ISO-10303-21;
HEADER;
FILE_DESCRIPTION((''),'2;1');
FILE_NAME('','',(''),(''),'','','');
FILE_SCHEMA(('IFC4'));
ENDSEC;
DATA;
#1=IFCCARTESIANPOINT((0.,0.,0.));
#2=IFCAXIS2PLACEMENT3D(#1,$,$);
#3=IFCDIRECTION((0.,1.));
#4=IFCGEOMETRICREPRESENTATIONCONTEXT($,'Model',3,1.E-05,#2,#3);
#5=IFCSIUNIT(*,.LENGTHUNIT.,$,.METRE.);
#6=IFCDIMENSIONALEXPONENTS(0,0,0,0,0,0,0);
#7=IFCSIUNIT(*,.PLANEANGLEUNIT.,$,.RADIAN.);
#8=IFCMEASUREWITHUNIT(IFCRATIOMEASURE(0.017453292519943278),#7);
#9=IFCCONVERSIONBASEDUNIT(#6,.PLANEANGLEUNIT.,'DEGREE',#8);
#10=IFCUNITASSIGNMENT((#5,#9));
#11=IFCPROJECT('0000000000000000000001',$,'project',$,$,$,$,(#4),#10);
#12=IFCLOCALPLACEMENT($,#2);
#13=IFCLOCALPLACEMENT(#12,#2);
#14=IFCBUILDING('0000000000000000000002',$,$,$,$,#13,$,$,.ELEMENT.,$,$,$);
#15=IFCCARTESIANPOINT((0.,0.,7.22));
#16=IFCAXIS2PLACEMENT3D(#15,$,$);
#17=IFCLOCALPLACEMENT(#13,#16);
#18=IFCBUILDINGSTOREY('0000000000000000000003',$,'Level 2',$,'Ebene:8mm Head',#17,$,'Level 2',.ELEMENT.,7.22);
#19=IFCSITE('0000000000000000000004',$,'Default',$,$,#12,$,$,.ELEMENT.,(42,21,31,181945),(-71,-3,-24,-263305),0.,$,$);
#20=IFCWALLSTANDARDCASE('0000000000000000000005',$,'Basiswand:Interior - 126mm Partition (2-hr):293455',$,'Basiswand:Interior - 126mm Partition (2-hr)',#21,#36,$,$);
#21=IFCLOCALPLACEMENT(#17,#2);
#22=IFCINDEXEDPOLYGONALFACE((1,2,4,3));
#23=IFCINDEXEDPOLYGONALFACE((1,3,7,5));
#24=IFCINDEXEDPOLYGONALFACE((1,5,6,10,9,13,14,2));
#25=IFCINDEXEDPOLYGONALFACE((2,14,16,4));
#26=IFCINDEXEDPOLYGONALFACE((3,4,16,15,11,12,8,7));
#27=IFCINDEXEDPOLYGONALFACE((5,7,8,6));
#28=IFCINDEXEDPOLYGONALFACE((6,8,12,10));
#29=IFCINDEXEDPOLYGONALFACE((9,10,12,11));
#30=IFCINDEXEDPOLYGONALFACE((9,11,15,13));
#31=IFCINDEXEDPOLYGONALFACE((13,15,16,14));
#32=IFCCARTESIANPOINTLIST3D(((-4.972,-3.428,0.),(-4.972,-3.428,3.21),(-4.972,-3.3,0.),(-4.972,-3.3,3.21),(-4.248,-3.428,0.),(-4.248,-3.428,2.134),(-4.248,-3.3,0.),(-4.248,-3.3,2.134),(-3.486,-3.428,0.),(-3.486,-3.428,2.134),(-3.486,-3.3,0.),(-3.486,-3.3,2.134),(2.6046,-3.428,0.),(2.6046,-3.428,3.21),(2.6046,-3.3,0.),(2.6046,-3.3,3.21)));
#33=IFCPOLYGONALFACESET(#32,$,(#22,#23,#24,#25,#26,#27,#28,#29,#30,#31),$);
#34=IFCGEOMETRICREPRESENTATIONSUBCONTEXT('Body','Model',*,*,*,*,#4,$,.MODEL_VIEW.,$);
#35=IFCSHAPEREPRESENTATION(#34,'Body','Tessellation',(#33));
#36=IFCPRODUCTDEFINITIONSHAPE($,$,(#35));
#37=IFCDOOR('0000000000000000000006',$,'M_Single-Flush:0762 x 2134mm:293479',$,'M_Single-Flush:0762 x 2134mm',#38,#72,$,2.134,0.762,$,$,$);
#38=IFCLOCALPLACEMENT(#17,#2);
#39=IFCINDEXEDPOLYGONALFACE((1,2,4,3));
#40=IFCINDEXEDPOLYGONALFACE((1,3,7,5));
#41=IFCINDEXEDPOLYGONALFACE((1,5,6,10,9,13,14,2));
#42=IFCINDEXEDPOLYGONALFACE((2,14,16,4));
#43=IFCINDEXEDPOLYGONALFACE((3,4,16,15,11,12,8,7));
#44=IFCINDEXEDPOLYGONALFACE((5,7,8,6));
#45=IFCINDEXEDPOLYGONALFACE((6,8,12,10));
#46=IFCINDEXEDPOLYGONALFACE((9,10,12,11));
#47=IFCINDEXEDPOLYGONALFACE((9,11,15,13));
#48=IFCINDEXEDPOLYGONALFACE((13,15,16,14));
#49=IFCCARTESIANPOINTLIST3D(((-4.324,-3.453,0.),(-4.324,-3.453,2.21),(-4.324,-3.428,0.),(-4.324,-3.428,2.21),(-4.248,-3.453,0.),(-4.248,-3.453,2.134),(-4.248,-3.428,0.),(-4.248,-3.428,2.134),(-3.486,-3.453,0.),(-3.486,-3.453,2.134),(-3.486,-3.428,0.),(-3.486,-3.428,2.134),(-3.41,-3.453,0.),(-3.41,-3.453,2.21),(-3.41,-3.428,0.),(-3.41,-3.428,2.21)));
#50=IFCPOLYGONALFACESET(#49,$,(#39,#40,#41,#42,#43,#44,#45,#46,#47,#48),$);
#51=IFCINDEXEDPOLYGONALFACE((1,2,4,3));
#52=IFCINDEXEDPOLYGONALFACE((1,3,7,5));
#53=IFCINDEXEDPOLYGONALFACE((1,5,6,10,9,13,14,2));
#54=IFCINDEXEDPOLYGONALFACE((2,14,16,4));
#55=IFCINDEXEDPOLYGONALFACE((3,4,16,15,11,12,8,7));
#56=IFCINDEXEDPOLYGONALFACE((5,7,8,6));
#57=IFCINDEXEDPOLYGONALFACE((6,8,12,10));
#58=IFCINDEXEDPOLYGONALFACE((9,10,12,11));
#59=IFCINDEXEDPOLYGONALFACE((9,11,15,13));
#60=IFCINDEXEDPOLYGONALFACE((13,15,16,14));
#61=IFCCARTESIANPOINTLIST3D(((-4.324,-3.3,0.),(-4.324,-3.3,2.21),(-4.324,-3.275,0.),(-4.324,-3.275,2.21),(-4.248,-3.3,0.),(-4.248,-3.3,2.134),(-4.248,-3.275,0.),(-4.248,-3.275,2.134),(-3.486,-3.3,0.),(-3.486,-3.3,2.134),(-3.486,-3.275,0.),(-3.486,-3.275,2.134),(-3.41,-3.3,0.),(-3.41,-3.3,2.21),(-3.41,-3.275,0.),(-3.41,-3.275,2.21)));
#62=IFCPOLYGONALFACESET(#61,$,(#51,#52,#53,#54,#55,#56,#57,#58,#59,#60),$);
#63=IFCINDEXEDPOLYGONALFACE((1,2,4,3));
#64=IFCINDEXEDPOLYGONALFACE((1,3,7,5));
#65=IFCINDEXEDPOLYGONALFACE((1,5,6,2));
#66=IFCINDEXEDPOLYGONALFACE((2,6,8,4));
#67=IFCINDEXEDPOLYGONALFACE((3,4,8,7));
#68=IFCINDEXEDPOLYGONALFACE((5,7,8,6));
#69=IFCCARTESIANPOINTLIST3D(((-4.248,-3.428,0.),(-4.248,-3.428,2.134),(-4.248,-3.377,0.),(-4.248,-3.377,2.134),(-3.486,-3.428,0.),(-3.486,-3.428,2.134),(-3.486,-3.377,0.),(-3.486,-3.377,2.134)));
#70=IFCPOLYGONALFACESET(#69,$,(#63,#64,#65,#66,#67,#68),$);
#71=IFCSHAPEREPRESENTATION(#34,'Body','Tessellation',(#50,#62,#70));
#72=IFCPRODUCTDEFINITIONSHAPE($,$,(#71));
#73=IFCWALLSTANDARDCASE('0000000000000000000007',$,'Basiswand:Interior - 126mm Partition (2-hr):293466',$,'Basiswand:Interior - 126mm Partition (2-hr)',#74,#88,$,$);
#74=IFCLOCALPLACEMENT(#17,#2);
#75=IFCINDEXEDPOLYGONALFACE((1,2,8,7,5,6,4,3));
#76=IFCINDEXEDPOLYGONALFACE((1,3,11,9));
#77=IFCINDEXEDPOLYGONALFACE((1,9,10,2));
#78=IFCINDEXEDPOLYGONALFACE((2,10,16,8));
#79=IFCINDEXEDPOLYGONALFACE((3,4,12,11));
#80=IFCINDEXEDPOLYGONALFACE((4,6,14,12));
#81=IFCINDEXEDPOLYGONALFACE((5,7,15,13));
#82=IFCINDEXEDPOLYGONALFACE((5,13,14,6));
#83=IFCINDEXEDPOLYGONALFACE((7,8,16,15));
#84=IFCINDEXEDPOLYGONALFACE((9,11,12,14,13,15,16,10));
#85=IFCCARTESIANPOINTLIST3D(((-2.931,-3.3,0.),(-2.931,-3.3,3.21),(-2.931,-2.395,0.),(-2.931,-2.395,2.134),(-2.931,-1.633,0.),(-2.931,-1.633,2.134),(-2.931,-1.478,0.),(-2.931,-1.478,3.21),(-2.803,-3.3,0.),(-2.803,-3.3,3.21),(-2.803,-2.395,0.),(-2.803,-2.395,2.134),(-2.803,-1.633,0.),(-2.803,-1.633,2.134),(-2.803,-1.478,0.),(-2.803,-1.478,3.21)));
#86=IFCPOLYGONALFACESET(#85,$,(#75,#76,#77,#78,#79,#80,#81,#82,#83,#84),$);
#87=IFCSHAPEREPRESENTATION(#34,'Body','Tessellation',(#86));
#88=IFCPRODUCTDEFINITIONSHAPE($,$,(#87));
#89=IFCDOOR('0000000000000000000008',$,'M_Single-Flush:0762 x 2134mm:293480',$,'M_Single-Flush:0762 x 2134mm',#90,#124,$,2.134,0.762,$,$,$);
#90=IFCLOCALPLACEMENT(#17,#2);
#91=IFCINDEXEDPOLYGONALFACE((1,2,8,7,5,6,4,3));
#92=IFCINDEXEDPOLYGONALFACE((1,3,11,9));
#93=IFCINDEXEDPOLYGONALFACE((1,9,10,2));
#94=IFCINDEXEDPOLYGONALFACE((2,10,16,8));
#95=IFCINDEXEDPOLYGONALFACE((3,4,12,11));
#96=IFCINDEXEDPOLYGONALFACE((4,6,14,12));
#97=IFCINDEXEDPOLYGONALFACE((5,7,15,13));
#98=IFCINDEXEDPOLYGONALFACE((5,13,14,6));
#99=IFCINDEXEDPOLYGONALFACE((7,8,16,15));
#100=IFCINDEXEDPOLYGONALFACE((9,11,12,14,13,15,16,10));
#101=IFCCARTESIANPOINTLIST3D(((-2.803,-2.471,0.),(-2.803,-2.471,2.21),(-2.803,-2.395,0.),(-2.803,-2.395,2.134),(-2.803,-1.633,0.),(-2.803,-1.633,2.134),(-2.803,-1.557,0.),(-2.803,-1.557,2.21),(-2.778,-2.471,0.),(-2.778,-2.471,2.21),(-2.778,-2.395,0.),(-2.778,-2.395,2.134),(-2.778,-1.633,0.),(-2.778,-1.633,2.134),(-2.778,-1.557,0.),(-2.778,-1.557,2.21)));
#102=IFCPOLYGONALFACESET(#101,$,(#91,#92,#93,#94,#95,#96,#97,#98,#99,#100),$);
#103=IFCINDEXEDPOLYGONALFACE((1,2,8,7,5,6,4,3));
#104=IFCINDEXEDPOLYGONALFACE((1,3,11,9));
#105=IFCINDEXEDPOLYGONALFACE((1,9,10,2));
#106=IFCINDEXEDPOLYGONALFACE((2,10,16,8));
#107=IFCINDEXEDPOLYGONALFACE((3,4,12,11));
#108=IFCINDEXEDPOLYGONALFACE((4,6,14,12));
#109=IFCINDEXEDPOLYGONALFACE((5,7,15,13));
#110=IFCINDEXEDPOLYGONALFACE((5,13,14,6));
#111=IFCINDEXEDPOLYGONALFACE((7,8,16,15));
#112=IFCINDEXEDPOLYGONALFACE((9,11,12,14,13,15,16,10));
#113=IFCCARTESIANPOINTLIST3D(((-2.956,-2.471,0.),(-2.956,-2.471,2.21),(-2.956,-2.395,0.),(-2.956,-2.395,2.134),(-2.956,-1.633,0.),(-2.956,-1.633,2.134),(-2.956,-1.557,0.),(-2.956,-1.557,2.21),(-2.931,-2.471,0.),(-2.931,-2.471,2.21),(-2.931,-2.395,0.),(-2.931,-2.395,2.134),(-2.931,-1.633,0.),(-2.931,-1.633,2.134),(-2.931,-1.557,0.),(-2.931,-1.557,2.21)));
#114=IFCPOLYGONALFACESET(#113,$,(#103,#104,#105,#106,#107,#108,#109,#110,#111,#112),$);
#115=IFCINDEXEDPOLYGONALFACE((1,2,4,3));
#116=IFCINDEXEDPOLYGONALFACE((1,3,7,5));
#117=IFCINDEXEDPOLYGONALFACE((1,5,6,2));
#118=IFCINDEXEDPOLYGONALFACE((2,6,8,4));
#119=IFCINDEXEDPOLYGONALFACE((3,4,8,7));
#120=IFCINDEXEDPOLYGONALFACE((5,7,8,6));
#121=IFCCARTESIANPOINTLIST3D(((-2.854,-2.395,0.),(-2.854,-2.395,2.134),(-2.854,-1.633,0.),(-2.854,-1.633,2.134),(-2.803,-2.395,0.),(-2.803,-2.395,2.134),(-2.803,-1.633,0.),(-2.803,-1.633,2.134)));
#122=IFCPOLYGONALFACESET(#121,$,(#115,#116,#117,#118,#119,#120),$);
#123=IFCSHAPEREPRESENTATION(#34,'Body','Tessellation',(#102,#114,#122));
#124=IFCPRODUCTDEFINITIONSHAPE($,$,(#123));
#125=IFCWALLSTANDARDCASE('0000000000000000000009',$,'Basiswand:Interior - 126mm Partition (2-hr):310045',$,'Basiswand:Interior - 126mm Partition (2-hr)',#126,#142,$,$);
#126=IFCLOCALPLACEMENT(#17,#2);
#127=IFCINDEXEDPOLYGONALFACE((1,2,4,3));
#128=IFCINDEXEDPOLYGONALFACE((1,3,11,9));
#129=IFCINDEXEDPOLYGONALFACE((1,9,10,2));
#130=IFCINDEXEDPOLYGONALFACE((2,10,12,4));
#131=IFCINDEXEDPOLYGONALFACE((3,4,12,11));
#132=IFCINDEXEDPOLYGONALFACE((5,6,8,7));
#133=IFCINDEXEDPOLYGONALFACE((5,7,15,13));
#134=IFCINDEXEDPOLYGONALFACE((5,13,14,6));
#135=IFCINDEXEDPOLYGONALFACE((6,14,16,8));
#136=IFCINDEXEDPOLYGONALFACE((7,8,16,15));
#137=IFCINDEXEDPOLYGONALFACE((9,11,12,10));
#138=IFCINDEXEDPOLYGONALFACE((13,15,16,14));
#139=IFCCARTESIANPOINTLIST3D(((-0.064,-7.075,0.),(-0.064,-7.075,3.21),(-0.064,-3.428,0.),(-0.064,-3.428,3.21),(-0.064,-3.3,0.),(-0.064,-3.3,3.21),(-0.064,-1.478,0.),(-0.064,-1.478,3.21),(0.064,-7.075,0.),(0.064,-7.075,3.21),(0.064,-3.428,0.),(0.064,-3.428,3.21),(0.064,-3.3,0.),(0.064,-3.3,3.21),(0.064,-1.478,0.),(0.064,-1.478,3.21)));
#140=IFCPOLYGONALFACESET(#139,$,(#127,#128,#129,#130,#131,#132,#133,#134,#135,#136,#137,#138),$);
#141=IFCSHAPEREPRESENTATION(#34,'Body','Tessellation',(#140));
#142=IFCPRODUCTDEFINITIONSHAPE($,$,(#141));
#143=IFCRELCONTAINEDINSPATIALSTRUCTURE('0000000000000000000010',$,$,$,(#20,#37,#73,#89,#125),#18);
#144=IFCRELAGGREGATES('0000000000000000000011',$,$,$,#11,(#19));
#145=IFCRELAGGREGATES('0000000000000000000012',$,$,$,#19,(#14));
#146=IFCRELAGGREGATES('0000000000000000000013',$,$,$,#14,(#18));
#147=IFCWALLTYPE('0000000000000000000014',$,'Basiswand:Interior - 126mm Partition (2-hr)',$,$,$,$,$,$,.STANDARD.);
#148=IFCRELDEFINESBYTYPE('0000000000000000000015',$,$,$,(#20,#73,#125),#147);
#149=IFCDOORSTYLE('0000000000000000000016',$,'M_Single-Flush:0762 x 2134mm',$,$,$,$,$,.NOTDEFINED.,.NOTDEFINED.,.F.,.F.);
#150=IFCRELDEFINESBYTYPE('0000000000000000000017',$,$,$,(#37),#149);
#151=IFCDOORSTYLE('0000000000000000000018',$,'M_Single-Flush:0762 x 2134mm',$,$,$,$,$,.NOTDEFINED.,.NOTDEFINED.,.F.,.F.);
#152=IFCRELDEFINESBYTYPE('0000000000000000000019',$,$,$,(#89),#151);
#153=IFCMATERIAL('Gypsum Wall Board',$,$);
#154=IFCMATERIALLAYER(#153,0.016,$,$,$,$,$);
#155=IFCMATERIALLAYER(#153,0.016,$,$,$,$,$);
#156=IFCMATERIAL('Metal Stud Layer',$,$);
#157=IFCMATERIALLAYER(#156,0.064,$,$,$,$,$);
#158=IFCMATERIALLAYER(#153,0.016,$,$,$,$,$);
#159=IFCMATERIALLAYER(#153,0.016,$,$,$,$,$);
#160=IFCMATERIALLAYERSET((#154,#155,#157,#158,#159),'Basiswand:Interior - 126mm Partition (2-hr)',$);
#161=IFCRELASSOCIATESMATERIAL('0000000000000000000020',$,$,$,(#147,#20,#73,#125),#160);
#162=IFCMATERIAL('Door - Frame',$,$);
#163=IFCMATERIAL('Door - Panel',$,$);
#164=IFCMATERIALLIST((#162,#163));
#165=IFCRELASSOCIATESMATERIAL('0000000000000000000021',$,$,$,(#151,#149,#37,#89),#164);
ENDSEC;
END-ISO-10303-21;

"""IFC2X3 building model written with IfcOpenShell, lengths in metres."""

from ifc_helpers import new_model, entity, si_unit, converted_unit, direction, frame, frame_2d, origin, place, context, subcontext, project, spatial, polyline, rectangle, outline, extrude, clip, bounded_halfspace, source, transform, mapped, material, material_list, layer, layer_set, layer_usage, type_object, type_shapes, element, fill, save


model = new_model("IFC2X3")

# Units and contexts
model_context = context("Model", 3, precision=1e-05, world=origin(), true_north=direction((0.0, 1.0)))
body_context = subcontext(model_context, "Body", "Model", "MODEL_VIEW")
ifc_project = project(units=[si_unit("LENGTHUNIT", "METRE"), converted_unit("PLANEANGLEUNIT", "DEGREE", entity("IfcRatioMeasure", 0.017453292519943278), si_unit("PLANEANGLEUNIT", "RADIAN"), dimensions=[0, 0, 0, 0, 0, 0, 0])], contexts=[model_context])

# Site, building, storey
site_placement = place(None, origin())
site = spatial("IfcSite", under=ifc_project, at=site_placement, Name="Default", CompositionType="ELEMENT", RefLatitude=(42, 21, 31, 181945), RefLongitude=(-71, -3, -24, -263305), RefElevation=0.0)
building_placement = place(site_placement, origin())
building = spatial("IfcBuilding", under=site, at=building_placement, CompositionType="ELEMENT")
storey_placement = place(building_placement, frame((0.0, 0.0, 7.22)))
storey = spatial("IfcBuildingStorey", under=building, at=storey_placement, Name="Level 2", ObjectType="Ebene:8mm Head", LongName="Level 2", CompositionType="ELEMENT", Elevation=7.22)

# Shared definitions
ifc_material_1 = material(Name="Gypsum Wall Board")
ifc_layer_1 = layer(ifc_material_1, 0.016)
ifc_layer_2 = layer(ifc_material_1, 0.016)
ifc_material_2 = material(Name="Metal Stud Layer")
ifc_layer_3 = layer(ifc_material_2, 0.064)
ifc_layer_4 = layer(ifc_material_1, 0.016)
ifc_layer_5 = layer(ifc_material_1, 0.016)
ifc_layer_set_1 = layer_set([ifc_layer_1, ifc_layer_2, ifc_layer_3, ifc_layer_4, ifc_layer_5], Name="Basiswand:Interior - 126mm Partition (2-hr)")
wall_type_1 = type_object("IfcWallType", Name="Basiswand:Interior - 126mm Partition (2-hr)", PredefinedType="STANDARD", material=ifc_layer_set_1)
ifc_material_3 = material(Name="Door - Frame")
ifc_material_4 = material(Name="Door - Panel")
ifc_material_list = material_list([ifc_material_3, ifc_material_4])

# Shared definitions
ifc_layer_usage_1 = layer_usage(ifc_layer_set_1, "AXIS2", "NEGATIVE", 0.064)
door_style_1 = type_object("IfcDoorStyle", Name="M_Single-Flush:0762 x 2134mm", ConstructionType="NOTDEFINED", OperationType="NOTDEFINED", ParameterTakesPrecedence=False, Sizeable=False, material=ifc_material_list)
shared_shape_1 = source(origin(), body_context, "Body", "SweptSolid", [
    extrude(outline(polyline([(-0.457, -1.124), (0.457, -1.124), (0.457, 1.086), (0.381, 1.086), (0.381, -1.048), (-0.381, -1.048), (-0.381, 1.086), (-0.457, 1.086), (-0.457, -1.124)])), frame((0.381, 0.153, 1.086), z_axis=(0.0, -1.0, 0.0), x_axis=(-1.0, 0.0, 0.0)), (0.0, 0.0, 1.0), 0.025),
    extrude(outline(polyline([(-1.124, -0.457), (1.086, -0.457), (1.086, -0.381), (-1.048, -0.381), (-1.048, 0.381), (1.086, 0.381), (1.086, 0.457), (-1.124, 0.457), (-1.124, -0.457)])), frame((0.381, 0.0, 1.086), z_axis=(0.0, -1.0, 0.0), x_axis=(0.0, 0.0, -1.0)), (0.0, 0.0, 1.0), 0.025),
    extrude(rectangle(XDim=0.762, YDim=0.051, at=frame_2d((0.0, 0.0), x_axis=(1.0, 0.0))), frame((0.381, 0.1025, 0.0)), (0.0, 0.0, 1.0), 2.134),
])
type_shapes(door_style_1, [shared_shape_1])
door_style_2 = type_object("IfcDoorStyle", Name="M_Single-Flush:0762 x 2134mm", ConstructionType="NOTDEFINED", OperationType="NOTDEFINED", ParameterTakesPrecedence=False, Sizeable=False, material=ifc_material_list)
shared_shape_2 = source(origin(), body_context, "Body", "SweptSolid", [
    extrude(outline(polyline([(-0.457, -1.124), (0.457, -1.124), (0.457, 1.086), (0.381, 1.086), (0.381, -1.048), (-0.381, -1.048), (-0.381, 1.086), (-0.457, 1.086), (-0.457, -1.124)])), frame((0.381, 0.128, 1.086), z_axis=(0.0, 1.0, 0.0), x_axis=(1.0, 0.0, 0.0)), (0.0, 0.0, 1.0), 0.025),
    extrude(outline(polyline([(-1.124, -0.457), (1.086, -0.457), (1.086, -0.381), (-1.048, -0.381), (-1.048, 0.381), (1.086, 0.381), (1.086, 0.457), (-1.124, 0.457), (-1.124, -0.457)])), frame((0.381, -0.025, 1.086), z_axis=(0.0, 1.0, 0.0), x_axis=(0.0, 0.0, -1.0)), (0.0, 0.0, 1.0), 0.025),
    extrude(rectangle(XDim=0.051, YDim=0.762, at=frame_2d((0.0, 0.0), x_axis=(1.0, 0.0))), frame((0.381, 0.1025, 0.0), z_axis=(0.0, 0.0, 1.0), x_axis=(0.0, 1.0, 0.0)), (0.0, 0.0, 1.0), 2.134),
])
type_shapes(door_style_2, [shared_shape_2])

# Walls, openings, doors
wall_1_placement = place(storey_placement, frame((-4.972, -3.364, 0.0)))
wall_1 = element("IfcWallStandardCase", 1, at=wall_1_placement, inside=storey, type_object=wall_type_1, material=ifc_layer_usage_1, Name="Basiswand:Interior - 126mm Partition (2-hr):293455", ObjectType="Basiswand:Interior - 126mm Partition (2-hr)", context=body_context, shape_type="Clipping", body=[
    clip(extrude(rectangle(XDim=7.5766, YDim=0.128, at=frame_2d((3.7883, 0.0), x_axis=(1.0, 0.0))), origin(), (0.0, 0.0, 1.0), 3.21), bounded_halfspace(frame((0.0, -0.064, 3.21), z_axis=(0.0, 0.0, -1.0), x_axis=(0.0, 1.0, 0.0)), True, frame((0.0, -0.064, 3.21)), polyline([(0.0, 0.0), (4.908, 0.0), (5.036, 0.0), (7.5766, 0.0), (7.5766, 0.128), (5.036, 0.128), (4.908, 0.128), (2.169, 0.128), (2.041, 0.128), (0.0, 0.128), (0.0, 0.0)]))),
])
opening_1_placement = place(wall_1_placement, frame((1.486, 0.064, 0.0)))
opening_1 = element("IfcOpeningElement", 2, at=opening_1_placement, cuts=wall_1, ObjectType="Opening", context=body_context, shape_type="SweptSolid", body=[
    extrude(rectangle(XDim=0.762, YDim=2.134, at=frame_2d((1.067, 0.381), x_axis=(0.0, 1.0))), frame((0.0, 0.0, 0.0), z_axis=(0.0, -1.0, 0.0), x_axis=(0.0, 0.0, 1.0)), (0.0, 0.0, 1.0), 0.128),
])
door_1_placement = place(opening_1_placement, frame((0.0, 0.0, 0.0), z_axis=(0.0, 0.0, 1.0), x_axis=(-1.0, 0.0, 0.0)))
door_1 = element("IfcDoor", 3, at=door_1_placement, inside=storey, type_object=door_style_2, material=ifc_material_list, Name="M_Single-Flush:0762 x 2134mm:293479", ObjectType="M_Single-Flush:0762 x 2134mm", OverallHeight=2.134, OverallWidth=0.762, context=body_context, shape_type="MappedRepresentation", body=[
    mapped(shared_shape_2, transform((0.0, 0.0, 0.0), scale=1.0)),
])
fill(opening_1, door_1)
wall_2_placement = place(storey_placement, frame((-2.867, -3.3, 0.0), z_axis=(0.0, 0.0, 1.0), x_axis=(0.0, 1.0, 0.0)))
wall_2 = element("IfcWallStandardCase", 4, at=wall_2_placement, inside=storey, type_object=wall_type_1, material=ifc_layer_usage_1, Name="Basiswand:Interior - 126mm Partition (2-hr):293466", ObjectType="Basiswand:Interior - 126mm Partition (2-hr)", context=body_context, shape_type="Clipping", body=[
    clip(extrude(rectangle(XDim=1.822, YDim=0.128, at=frame_2d((0.911, 0.0), x_axis=(1.0, 0.0))), origin(), (0.0, 0.0, 1.0), 3.21), bounded_halfspace(frame((0.0, -0.064, 3.21), z_axis=(0.0, 0.0, -1.0), x_axis=(1.0, 0.0, 0.0)), True, frame((0.0, -0.064, 3.21)), polyline([(0.0, 0.0), (1.822, 0.0), (1.822, 0.128), (0.0, 0.128), (0.0, 0.0)]))),
])
opening_2_placement = place(wall_2_placement, frame((1.667, 0.064, 0.0)))
opening_2 = element("IfcOpeningElement", 5, at=opening_2_placement, cuts=wall_2, ObjectType="Opening", context=body_context, shape_type="SweptSolid", body=[
    extrude(rectangle(XDim=0.762, YDim=2.134, at=frame_2d((1.067, 0.381), x_axis=(0.0, -1.0))), frame((0.0, 0.0, 0.0), z_axis=(0.0, -1.0, 0.0), x_axis=(0.0, 0.0, 1.0)), (0.0, 0.0, 1.0), 0.128),
])
door_2_placement = place(opening_2_placement, frame((0.0, 0.0, 0.0), z_axis=(0.0, 0.0, 1.0), x_axis=(-1.0, 0.0, 0.0)))
door_2 = element("IfcDoor", 6, at=door_2_placement, inside=storey, type_object=door_style_1, material=ifc_material_list, Name="M_Single-Flush:0762 x 2134mm:293480", ObjectType="M_Single-Flush:0762 x 2134mm", OverallHeight=2.134, OverallWidth=0.762, context=body_context, shape_type="MappedRepresentation", body=[
    mapped(shared_shape_1, transform((0.0, 0.0, 0.0), scale=1.0)),
])
fill(opening_2, door_2)

# Wall, opening
wall_3_placement = place(storey_placement, frame((0.0, -1.478, 0.0), z_axis=(0.0, 0.0, 1.0), x_axis=(0.0, -1.0, 0.0)))
wall_3 = element("IfcWallStandardCase", 7, at=wall_3_placement, inside=storey, type_object=wall_type_1, material=ifc_layer_usage_1, Name="Basiswand:Interior - 126mm Partition (2-hr):310045", ObjectType="Basiswand:Interior - 126mm Partition (2-hr)", context=body_context, shape_type="SweptSolid", body=[
    extrude(rectangle(XDim=5.597, YDim=0.128, at=frame_2d((2.7985, 0.0), x_axis=(-1.0, 0.0))), origin(), (0.0, 0.0, 1.0), 3.21),
])
opening_3_placement = place(storey_placement, frame((0.0, -1.478, 0.0), z_axis=(0.0, 0.0, 1.0), x_axis=(0.0, -1.0, 0.0)))
element("IfcOpeningElement", 8, at=opening_3_placement, cuts=wall_3, ObjectType="Opening", context=body_context, shape_type="SweptSolid", body=[
    extrude(rectangle(XDim=3.21, YDim=0.128, at=frame_2d((0.0, 0.0), x_axis=(1.0, 0.0))), frame((1.95, 0.0, 1.605), z_axis=(-1.0, 0.0, 0.0), x_axis=(0.0, 0.0, 1.0)), (0.0, 0.0, 1.0), 0.128),
])

save(model, "model.ifc")
